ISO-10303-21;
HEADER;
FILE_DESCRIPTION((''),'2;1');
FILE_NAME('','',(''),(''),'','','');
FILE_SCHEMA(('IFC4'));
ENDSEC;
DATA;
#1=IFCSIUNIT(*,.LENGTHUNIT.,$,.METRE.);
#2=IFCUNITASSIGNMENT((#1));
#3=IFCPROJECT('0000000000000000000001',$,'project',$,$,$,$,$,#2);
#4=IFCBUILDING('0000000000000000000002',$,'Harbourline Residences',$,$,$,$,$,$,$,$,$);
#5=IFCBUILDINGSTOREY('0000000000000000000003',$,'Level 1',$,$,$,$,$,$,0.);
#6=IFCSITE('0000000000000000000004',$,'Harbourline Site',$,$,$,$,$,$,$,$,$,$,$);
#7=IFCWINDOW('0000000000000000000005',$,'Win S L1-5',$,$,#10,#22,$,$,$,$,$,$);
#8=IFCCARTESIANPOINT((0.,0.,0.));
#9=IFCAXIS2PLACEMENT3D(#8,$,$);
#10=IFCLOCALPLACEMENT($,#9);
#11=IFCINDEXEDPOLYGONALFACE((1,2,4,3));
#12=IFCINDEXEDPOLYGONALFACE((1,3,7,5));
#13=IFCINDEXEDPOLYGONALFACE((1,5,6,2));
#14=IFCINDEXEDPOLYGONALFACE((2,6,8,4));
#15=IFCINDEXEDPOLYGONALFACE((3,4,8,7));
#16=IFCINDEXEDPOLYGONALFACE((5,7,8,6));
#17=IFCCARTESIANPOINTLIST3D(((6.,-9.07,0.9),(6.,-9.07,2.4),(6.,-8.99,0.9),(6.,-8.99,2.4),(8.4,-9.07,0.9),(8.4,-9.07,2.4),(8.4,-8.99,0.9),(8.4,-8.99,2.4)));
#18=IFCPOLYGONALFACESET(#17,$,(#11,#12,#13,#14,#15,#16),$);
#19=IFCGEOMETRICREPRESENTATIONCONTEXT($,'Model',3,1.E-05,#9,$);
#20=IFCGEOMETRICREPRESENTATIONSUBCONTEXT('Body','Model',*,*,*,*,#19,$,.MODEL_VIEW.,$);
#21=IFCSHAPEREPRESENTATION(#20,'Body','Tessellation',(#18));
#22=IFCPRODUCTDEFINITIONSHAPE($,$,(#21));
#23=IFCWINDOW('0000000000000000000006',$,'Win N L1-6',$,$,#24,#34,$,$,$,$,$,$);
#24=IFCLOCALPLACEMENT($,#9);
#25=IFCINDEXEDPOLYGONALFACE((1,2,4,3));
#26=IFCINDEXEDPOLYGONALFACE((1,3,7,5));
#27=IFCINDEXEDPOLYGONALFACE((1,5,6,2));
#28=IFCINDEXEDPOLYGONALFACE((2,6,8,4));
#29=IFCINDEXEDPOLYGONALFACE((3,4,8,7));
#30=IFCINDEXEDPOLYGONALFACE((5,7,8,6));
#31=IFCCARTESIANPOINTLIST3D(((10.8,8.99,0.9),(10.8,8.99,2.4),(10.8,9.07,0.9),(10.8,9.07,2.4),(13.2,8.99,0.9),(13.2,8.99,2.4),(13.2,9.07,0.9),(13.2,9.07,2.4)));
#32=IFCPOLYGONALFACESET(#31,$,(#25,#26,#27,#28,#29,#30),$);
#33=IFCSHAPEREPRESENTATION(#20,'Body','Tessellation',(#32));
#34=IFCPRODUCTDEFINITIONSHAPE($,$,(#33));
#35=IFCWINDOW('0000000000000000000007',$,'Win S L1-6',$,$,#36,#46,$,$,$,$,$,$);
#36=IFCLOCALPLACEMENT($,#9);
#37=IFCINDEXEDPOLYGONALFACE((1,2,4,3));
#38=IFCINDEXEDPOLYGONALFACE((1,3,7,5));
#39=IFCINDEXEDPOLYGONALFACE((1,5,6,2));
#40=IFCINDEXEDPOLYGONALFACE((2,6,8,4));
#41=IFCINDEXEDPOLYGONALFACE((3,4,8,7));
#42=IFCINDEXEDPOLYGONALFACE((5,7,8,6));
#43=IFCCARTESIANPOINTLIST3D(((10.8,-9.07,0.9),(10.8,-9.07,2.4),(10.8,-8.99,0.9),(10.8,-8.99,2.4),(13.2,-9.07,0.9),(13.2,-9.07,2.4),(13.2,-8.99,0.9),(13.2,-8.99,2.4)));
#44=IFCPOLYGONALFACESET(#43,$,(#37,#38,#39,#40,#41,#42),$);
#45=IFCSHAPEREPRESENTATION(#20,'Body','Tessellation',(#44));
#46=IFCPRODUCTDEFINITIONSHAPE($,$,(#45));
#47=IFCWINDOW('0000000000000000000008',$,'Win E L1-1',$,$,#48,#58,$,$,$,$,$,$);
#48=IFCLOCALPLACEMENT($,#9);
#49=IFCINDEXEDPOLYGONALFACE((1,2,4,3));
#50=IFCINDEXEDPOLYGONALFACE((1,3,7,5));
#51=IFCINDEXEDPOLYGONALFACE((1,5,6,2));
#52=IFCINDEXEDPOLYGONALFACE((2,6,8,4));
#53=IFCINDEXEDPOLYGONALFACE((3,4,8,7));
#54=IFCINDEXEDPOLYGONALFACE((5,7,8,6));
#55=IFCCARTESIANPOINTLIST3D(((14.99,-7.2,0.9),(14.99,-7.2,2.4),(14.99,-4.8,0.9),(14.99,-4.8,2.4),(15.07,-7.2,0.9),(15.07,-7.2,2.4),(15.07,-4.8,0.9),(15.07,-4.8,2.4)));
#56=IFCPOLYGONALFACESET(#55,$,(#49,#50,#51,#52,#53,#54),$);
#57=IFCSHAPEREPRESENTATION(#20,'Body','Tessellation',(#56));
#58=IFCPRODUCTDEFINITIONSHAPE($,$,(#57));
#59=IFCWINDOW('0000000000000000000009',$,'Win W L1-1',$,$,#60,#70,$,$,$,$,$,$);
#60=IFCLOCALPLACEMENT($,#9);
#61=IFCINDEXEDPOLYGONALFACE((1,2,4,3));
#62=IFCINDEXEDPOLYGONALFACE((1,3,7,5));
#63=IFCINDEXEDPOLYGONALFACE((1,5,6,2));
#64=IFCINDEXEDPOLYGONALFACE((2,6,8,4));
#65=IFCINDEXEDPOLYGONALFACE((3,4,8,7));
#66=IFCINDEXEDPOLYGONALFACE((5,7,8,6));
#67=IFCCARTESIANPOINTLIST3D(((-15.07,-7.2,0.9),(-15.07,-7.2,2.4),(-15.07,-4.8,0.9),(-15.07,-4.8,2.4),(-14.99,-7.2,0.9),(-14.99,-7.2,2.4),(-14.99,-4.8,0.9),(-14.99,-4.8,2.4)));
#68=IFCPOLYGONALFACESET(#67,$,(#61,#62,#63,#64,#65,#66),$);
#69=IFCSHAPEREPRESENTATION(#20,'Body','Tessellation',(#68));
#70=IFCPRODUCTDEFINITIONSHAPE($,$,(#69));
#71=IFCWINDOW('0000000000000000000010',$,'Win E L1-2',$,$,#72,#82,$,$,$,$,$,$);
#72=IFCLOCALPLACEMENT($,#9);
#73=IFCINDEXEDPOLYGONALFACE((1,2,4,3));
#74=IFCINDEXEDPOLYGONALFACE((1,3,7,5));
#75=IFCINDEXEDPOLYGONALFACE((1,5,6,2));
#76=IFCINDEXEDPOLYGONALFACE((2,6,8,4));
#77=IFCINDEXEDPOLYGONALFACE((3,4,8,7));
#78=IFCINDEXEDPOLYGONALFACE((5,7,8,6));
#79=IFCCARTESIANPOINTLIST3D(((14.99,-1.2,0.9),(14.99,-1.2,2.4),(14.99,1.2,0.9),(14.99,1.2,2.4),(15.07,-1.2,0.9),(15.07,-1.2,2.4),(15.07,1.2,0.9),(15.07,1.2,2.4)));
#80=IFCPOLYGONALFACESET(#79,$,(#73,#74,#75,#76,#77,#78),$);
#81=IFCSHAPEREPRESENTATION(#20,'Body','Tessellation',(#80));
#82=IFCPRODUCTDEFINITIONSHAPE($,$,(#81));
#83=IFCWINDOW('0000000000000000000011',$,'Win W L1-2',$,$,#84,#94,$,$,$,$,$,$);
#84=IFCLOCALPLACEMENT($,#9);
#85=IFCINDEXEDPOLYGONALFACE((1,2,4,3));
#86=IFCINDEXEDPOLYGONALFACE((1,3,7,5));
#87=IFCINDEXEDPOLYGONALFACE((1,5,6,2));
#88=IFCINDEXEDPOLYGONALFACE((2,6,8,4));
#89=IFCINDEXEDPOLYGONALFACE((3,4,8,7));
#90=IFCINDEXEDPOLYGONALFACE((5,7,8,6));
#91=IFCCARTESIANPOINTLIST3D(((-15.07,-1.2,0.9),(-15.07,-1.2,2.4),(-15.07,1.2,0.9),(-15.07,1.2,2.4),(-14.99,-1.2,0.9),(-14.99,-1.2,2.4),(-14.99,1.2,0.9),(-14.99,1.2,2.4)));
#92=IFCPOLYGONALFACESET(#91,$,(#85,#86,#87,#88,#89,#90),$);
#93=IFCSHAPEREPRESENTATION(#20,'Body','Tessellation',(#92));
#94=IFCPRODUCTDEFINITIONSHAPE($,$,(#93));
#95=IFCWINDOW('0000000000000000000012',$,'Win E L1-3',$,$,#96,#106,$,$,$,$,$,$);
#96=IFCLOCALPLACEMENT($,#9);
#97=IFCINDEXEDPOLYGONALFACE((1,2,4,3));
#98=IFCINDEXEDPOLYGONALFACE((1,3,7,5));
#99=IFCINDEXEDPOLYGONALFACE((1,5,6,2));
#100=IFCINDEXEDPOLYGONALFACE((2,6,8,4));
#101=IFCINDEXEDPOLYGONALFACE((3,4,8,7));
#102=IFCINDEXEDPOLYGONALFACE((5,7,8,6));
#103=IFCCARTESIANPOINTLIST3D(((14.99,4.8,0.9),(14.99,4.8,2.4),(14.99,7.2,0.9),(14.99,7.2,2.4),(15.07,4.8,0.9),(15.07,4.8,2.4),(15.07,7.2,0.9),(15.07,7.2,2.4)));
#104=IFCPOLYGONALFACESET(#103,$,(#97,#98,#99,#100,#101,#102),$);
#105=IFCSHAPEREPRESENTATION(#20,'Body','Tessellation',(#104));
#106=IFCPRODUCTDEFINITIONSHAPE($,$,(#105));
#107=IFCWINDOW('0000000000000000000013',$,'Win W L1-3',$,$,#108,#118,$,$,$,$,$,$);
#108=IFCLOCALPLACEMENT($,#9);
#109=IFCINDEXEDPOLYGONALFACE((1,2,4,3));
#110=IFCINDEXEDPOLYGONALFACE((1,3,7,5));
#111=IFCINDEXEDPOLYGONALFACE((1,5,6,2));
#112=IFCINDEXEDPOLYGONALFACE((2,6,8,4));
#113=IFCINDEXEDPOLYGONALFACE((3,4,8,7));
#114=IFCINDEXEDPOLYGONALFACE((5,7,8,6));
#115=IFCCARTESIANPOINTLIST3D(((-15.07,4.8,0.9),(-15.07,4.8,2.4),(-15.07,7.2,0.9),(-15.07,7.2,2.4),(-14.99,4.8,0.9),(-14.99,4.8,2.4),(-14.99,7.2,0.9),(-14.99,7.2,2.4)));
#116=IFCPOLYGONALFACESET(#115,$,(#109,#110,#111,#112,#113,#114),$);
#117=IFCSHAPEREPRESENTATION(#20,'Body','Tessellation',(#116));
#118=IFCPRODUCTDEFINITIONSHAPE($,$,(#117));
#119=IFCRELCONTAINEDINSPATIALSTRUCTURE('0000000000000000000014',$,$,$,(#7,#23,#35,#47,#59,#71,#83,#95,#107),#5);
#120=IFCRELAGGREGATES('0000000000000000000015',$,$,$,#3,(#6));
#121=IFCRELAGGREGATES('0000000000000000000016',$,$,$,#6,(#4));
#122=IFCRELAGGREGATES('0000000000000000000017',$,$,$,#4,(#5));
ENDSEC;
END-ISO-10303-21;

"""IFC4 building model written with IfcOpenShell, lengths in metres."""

from ifc_helpers import new_model, si_unit, frame, frame_2d, origin, context, subcontext, project, spatial, rectangle, extrude, element, save


model = new_model("IFC4")

# Units and contexts
model_context = context("Model", 3, precision=1e-05, world=origin())
body_context = subcontext(model_context, "Body", "Model", "MODEL_VIEW")
ifc_project = project(units=[si_unit("LENGTHUNIT", "METRE")])

# Site, building, storey
site = spatial("IfcSite", under=ifc_project, Name="Harbourline Site")
building = spatial("IfcBuilding", under=site, Name="Harbourline Residences")
storey = spatial("IfcBuildingStorey", under=building, Name="Level 1", Elevation=0.0)

# Windows
element("IfcWindow", 1, inside=storey, Name="Win S L1-5", context=body_context, shape_type="SweptSolid", body=[
    extrude(rectangle(XDim=2.4, YDim=0.08, at=frame_2d((7.2, -9.03))), frame((0.0, 0.0, 0.9)), (0.0, 0.0, 1.0), 1.5),
])
element("IfcWindow", 2, inside=storey, Name="Win N L1-6", context=body_context, shape_type="SweptSolid", body=[
    extrude(rectangle(XDim=2.4, YDim=0.08, at=frame_2d((12.0, 9.03))), frame((0.0, 0.0, 0.9)), (0.0, 0.0, 1.0), 1.5),
])
element("IfcWindow", 3, inside=storey, Name="Win S L1-6", context=body_context, shape_type="SweptSolid", body=[
    extrude(rectangle(XDim=2.4, YDim=0.08, at=frame_2d((12.0, -9.03))), frame((0.0, 0.0, 0.9)), (0.0, 0.0, 1.0), 1.5),
])
element("IfcWindow", 4, inside=storey, Name="Win E L1-1", context=body_context, shape_type="SweptSolid", body=[
    extrude(rectangle(XDim=0.08, YDim=2.4, at=frame_2d((15.03, -6.0))), frame((0.0, 0.0, 0.9)), (0.0, 0.0, 1.0), 1.5),
])
element("IfcWindow", 5, inside=storey, Name="Win W L1-1", context=body_context, shape_type="SweptSolid", body=[
    extrude(rectangle(XDim=0.08, YDim=2.4, at=frame_2d((-15.03, -6.0))), frame((0.0, 0.0, 0.9)), (0.0, 0.0, 1.0), 1.5),
])
element("IfcWindow", 6, inside=storey, Name="Win E L1-2", context=body_context, shape_type="SweptSolid", body=[
    extrude(rectangle(XDim=0.08, YDim=2.4, at=frame_2d((15.03, 0.0))), frame((0.0, 0.0, 0.9)), (0.0, 0.0, 1.0), 1.5),
])
element("IfcWindow", 7, inside=storey, Name="Win W L1-2", context=body_context, shape_type="SweptSolid", body=[
    extrude(rectangle(XDim=0.08, YDim=2.4, at=frame_2d((-15.03, 0.0))), frame((0.0, 0.0, 0.9)), (0.0, 0.0, 1.0), 1.5),
])
element("IfcWindow", 8, inside=storey, Name="Win E L1-3", context=body_context, shape_type="SweptSolid", body=[
    extrude(rectangle(XDim=0.08, YDim=2.4, at=frame_2d((15.03, 6.0))), frame((0.0, 0.0, 0.9)), (0.0, 0.0, 1.0), 1.5),
])
element("IfcWindow", 9, inside=storey, Name="Win W L1-3", context=body_context, shape_type="SweptSolid", body=[
    extrude(rectangle(XDim=0.08, YDim=2.4, at=frame_2d((-15.03, 6.0))), frame((0.0, 0.0, 0.9)), (0.0, 0.0, 1.0), 1.5),
])

save(model, "model.ifc")
